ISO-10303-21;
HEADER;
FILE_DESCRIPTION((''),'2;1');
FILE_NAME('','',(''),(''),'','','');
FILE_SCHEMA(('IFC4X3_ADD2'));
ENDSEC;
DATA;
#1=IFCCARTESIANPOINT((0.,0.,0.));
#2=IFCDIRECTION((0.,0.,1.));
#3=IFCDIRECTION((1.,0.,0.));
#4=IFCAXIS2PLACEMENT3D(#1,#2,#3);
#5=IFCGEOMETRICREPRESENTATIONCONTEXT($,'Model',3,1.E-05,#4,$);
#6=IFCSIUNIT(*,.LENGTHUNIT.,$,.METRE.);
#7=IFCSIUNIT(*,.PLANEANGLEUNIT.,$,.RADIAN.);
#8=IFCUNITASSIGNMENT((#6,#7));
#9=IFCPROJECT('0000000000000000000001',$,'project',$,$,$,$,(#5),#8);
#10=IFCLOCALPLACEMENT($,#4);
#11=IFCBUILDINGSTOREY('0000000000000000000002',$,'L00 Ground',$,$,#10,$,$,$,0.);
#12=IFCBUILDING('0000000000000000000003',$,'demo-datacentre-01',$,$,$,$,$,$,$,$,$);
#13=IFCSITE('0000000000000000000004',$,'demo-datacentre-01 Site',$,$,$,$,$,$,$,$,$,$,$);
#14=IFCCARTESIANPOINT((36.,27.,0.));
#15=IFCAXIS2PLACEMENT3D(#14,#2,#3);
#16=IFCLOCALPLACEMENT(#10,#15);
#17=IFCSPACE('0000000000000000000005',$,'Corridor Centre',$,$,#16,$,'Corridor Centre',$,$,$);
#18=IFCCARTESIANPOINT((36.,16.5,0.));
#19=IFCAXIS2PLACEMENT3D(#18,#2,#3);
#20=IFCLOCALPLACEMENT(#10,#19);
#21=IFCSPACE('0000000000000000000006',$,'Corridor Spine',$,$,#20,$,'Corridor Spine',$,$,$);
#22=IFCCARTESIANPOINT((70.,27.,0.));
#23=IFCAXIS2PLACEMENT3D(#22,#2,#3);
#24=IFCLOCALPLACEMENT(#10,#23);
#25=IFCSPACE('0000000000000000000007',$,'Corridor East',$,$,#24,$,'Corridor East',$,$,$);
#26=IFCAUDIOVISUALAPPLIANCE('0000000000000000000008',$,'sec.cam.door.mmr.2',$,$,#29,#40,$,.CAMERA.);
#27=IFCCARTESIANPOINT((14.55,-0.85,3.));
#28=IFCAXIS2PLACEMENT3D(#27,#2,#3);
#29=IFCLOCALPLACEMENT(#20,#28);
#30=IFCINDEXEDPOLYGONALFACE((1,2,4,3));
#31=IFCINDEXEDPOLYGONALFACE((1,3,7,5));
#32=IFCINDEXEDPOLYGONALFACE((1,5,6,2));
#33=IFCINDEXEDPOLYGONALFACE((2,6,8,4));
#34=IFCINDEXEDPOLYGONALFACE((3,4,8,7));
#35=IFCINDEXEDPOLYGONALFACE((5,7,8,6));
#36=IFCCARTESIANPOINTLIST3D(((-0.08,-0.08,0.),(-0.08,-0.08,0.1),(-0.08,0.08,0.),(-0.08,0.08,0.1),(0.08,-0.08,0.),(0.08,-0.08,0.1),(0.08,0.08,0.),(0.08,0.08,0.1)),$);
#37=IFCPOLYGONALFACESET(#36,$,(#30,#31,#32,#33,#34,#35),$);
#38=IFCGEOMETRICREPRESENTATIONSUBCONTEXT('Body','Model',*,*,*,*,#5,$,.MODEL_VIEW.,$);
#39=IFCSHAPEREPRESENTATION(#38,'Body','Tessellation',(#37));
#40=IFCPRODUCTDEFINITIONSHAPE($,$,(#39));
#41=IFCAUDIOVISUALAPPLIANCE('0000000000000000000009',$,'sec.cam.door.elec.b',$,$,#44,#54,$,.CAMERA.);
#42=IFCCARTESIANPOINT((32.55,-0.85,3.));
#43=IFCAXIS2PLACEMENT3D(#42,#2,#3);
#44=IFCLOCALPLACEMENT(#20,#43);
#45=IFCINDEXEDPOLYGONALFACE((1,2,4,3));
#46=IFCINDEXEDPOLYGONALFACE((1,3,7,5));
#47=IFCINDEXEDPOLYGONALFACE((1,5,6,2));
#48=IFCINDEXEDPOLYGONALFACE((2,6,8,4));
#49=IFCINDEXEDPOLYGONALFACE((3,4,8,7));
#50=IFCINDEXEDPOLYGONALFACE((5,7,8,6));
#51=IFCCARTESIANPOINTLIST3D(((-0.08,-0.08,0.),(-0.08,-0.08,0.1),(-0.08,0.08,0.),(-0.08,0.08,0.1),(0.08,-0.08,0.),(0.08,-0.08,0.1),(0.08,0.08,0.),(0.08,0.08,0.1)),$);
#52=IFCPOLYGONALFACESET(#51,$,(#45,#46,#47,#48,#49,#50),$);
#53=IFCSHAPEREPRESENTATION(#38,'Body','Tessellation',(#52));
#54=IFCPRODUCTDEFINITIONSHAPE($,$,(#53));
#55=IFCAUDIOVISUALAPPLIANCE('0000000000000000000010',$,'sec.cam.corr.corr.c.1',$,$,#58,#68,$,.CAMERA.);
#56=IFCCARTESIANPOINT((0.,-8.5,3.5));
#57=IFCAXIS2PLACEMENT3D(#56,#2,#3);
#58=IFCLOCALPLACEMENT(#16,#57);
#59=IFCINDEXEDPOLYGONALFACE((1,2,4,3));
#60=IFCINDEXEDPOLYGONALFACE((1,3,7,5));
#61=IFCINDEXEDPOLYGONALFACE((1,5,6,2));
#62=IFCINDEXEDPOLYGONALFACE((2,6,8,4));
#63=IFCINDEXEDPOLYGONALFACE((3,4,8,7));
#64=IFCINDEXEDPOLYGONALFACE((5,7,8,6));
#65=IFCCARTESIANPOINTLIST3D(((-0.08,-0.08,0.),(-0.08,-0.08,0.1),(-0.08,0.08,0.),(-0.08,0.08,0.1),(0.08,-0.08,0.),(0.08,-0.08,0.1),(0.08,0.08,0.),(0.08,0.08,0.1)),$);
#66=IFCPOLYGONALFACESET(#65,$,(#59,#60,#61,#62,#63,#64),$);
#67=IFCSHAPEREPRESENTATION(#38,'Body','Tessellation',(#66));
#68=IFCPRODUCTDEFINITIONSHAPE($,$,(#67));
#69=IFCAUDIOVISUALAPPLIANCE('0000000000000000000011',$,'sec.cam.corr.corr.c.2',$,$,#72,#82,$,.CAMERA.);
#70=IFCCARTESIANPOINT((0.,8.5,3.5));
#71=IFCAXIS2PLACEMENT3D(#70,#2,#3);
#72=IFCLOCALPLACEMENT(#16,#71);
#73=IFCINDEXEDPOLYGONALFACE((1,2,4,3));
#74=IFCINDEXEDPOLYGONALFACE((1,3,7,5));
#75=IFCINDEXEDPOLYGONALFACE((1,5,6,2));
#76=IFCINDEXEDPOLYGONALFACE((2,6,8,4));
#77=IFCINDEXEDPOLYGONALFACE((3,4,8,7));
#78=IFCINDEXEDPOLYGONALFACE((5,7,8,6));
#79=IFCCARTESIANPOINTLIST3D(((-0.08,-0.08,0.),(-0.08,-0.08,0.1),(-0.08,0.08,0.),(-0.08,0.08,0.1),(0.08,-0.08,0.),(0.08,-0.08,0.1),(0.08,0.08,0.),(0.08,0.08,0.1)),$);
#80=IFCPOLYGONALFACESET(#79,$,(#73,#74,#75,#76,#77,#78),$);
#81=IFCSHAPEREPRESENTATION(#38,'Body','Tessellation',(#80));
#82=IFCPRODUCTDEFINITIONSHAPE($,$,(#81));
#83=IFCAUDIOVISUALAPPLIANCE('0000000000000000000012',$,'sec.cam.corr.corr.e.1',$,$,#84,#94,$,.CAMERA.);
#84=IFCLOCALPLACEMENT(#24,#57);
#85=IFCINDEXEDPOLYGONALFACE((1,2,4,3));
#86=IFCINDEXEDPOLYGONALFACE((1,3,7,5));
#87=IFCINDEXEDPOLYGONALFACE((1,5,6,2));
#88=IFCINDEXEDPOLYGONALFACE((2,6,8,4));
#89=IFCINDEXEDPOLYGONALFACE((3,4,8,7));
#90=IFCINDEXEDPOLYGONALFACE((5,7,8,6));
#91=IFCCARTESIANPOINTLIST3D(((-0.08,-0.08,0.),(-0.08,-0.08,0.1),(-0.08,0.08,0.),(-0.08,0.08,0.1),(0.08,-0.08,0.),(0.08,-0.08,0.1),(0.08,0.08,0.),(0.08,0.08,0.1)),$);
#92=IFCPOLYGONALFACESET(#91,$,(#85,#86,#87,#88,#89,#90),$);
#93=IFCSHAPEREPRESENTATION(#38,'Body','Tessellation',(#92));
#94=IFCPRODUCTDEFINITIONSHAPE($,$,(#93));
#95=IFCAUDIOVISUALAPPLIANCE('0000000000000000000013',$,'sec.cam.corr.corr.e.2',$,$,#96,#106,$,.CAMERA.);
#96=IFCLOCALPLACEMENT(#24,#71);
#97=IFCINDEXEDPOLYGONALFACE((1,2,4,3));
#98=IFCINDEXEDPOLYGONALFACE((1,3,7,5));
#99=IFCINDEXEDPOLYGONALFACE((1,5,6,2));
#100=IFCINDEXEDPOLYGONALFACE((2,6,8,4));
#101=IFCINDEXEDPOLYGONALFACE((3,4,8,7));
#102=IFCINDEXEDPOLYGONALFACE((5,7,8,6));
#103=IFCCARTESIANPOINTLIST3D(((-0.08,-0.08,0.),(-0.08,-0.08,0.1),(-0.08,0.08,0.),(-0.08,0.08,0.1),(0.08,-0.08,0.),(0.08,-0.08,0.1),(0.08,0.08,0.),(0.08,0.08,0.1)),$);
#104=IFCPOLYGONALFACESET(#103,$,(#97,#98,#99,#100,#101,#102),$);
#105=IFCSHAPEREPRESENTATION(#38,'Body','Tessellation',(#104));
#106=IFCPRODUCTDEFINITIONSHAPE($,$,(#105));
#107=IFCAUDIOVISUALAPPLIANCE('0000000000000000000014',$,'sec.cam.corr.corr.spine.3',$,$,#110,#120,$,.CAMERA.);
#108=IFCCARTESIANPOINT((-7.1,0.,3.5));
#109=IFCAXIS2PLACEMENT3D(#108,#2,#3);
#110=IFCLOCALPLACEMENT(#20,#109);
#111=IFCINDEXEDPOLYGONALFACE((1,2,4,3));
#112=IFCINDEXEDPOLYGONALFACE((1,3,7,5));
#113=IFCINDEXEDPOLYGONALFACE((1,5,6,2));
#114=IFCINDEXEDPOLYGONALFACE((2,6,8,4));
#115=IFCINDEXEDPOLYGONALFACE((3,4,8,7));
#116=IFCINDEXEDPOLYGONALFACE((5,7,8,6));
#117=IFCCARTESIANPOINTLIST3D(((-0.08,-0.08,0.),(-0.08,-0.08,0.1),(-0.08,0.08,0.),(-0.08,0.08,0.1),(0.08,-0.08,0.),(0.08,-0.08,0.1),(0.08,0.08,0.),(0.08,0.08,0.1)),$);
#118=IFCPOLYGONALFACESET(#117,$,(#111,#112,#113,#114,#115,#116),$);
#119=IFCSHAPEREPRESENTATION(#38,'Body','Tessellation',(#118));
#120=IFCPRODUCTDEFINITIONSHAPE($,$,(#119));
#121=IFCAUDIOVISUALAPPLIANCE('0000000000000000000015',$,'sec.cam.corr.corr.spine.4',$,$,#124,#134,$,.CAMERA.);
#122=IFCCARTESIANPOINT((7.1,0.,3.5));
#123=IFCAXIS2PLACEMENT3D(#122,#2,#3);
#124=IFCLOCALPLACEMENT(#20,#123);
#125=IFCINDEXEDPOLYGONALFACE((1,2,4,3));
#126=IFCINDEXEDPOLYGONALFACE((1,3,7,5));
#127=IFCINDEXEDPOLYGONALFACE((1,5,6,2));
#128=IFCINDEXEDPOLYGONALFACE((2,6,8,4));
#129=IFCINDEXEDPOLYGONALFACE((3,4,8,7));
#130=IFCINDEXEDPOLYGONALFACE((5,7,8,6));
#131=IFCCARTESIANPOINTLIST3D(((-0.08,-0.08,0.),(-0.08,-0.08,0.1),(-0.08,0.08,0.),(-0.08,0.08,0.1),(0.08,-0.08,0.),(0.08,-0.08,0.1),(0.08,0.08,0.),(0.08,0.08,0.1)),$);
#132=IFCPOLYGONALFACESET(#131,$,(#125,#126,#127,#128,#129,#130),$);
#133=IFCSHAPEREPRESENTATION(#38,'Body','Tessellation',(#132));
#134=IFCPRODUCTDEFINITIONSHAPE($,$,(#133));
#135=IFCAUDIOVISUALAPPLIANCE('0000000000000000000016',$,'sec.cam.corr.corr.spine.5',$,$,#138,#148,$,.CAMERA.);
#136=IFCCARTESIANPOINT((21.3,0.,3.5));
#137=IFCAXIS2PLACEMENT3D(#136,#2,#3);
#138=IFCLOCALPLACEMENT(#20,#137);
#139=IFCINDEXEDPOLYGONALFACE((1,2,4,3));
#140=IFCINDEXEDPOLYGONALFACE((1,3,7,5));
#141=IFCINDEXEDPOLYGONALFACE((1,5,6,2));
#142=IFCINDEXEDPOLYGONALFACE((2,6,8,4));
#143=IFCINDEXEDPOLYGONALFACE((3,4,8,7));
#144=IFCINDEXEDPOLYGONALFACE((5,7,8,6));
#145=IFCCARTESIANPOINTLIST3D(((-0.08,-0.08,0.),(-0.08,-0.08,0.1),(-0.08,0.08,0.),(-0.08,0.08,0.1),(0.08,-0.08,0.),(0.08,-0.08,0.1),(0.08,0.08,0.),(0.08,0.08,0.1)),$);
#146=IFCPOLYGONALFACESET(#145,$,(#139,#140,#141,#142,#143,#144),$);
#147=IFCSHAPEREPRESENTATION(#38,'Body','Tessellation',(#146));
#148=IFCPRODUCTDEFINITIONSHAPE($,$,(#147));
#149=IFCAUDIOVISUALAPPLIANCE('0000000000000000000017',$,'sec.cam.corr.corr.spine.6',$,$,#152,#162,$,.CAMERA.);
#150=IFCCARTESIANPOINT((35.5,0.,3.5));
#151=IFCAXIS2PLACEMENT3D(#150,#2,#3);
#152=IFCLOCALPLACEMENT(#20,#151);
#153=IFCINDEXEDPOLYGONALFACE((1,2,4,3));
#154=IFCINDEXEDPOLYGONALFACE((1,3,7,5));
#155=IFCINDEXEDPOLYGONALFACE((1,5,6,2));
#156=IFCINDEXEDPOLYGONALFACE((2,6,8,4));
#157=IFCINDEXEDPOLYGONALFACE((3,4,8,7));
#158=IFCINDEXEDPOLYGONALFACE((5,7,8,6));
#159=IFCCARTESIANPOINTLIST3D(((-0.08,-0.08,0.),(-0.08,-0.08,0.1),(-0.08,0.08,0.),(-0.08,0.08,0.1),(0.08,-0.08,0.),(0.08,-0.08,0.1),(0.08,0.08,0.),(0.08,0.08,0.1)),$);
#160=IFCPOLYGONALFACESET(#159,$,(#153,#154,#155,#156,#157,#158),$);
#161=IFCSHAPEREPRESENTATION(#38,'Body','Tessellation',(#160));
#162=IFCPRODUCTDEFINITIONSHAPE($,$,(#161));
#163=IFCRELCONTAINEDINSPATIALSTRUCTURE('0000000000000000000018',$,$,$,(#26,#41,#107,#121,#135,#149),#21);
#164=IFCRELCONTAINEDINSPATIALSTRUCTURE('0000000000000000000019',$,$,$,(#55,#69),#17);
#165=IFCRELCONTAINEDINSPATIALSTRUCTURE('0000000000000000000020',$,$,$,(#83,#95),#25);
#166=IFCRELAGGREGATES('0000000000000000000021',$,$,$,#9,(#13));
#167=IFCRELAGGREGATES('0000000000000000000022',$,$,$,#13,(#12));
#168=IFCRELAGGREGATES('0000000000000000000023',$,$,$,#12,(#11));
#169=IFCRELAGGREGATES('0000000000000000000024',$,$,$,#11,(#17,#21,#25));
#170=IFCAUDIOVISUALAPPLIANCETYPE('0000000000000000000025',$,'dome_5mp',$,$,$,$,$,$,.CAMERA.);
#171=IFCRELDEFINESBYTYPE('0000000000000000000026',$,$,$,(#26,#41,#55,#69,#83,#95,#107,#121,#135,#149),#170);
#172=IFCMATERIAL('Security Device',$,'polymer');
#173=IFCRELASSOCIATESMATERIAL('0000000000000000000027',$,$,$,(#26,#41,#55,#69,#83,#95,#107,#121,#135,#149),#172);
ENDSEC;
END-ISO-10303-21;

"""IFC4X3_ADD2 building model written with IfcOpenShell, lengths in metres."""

from ifc_helpers import new_model, si_unit, frame, origin_with_axes, place, context, subcontext, project, spatial, rectangle, extrude, source, transform, mapped, material, type_object, type_shapes, element, save


model = new_model("IFC4X3_ADD2")

# Units and contexts
model_context = context("Model", 3, precision=1e-05, world=origin_with_axes())
body_context = subcontext(model_context, "Body", "Model", "MODEL_VIEW")
ifc_project = project(units=[si_unit("LENGTHUNIT", "METRE"), si_unit("PLANEANGLEUNIT", "RADIAN")], contexts=[model_context])

# Site, building, storey
site = spatial("IfcSite", under=ifc_project, Name="demo-datacentre-01 Site")
building = spatial("IfcBuilding", under=site, Name="demo-datacentre-01")
storey_placement = place(None, origin_with_axes())
storey = spatial("IfcBuildingStorey", under=building, at=storey_placement, Name="L00 Ground", Elevation=0.0)

# Shared definitions
ifc_material = material(Name="Security Device", Category="polymer")

# Shared definitions
space_1_placement = place(storey_placement, frame((36.0, 27.0, 0.0), z_axis=(0.0, 0.0, 1.0), x_axis=(1.0, 0.0, 0.0)))
space_1 = spatial("IfcSpace", under=storey, at=space_1_placement, Name="Corridor Centre", LongName="Corridor Centre")

# Shared definitions
space_2_placement = place(storey_placement, frame((36.0, 16.5, 0.0), z_axis=(0.0, 0.0, 1.0), x_axis=(1.0, 0.0, 0.0)))
space_2 = spatial("IfcSpace", under=storey, at=space_2_placement, Name="Corridor Spine", LongName="Corridor Spine")

# Shared definitions
space_3_placement = place(storey_placement, frame((70.0, 27.0, 0.0), z_axis=(0.0, 0.0, 1.0), x_axis=(1.0, 0.0, 0.0)))
space_3 = spatial("IfcSpace", under=storey, at=space_3_placement, Name="Corridor East", LongName="Corridor East")

# Audio visual appliances
audio_visual_appliance_type = type_object("IfcAudioVisualApplianceType", Name="dome_5mp", PredefinedType="CAMERA")
shared_shape = source(origin_with_axes(), body_context, "Body", "SweptSolid", [
    extrude(rectangle(XDim=0.16, YDim=0.16), origin_with_axes(), (0.0, 0.0, 1.0), 0.1),
])
type_shapes(audio_visual_appliance_type, [shared_shape])
for number, where, z_axis, x_axis, name in (
    (1, (14.55, -0.85, 3.0), (0.0, 0.0, 1.0), (1.0, 0.0, 0.0), "sec.cam.door.mmr.2"),
    (2, (32.55, -0.85, 3.0), (0.0, 0.0, 1.0), (1.0, 0.0, 0.0), "sec.cam.door.elec.b"),
):
    element("IfcAudioVisualAppliance", number, at=place(space_2_placement, frame(where, z_axis=z_axis, x_axis=x_axis)), inside=space_2, type_object=audio_visual_appliance_type, material=ifc_material, Name=name, PredefinedType="CAMERA", context=body_context, shape_type="MappedRepresentation", body=[
        mapped(shared_shape, transform((0.0, 0.0, 0.0), x_axis=(1.0, 0.0, 0.0), y_axis=(0.0, 1.0, 0.0), z_axis=(0.0, 0.0, 1.0), scale=1.0)),
    ])
for number, where, z_axis, x_axis, name in (
    (3, (0.0, -8.5, 3.5), (0.0, 0.0, 1.0), (1.0, 0.0, 0.0), "sec.cam.corr.corr.c.1"),
    (4, (0.0, 8.5, 3.5), (0.0, 0.0, 1.0), (1.0, 0.0, 0.0), "sec.cam.corr.corr.c.2"),
):
    element("IfcAudioVisualAppliance", number, at=place(space_1_placement, frame(where, z_axis=z_axis, x_axis=x_axis)), inside=space_1, type_object=audio_visual_appliance_type, material=ifc_material, Name=name, PredefinedType="CAMERA", context=body_context, shape_type="MappedRepresentation", body=[
        mapped(shared_shape, transform((0.0, 0.0, 0.0), x_axis=(1.0, 0.0, 0.0), y_axis=(0.0, 1.0, 0.0), z_axis=(0.0, 0.0, 1.0), scale=1.0)),
    ])
for number, where, z_axis, x_axis, name in (
    (5, (0.0, -8.5, 3.5), (0.0, 0.0, 1.0), (1.0, 0.0, 0.0), "sec.cam.corr.corr.e.1"),
    (6, (0.0, 8.5, 3.5), (0.0, 0.0, 1.0), (1.0, 0.0, 0.0), "sec.cam.corr.corr.e.2"),
):
    element("IfcAudioVisualAppliance", number, at=place(space_3_placement, frame(where, z_axis=z_axis, x_axis=x_axis)), inside=space_3, type_object=audio_visual_appliance_type, material=ifc_material, Name=name, PredefinedType="CAMERA", context=body_context, shape_type="MappedRepresentation", body=[
        mapped(shared_shape, transform((0.0, 0.0, 0.0), x_axis=(1.0, 0.0, 0.0), y_axis=(0.0, 1.0, 0.0), z_axis=(0.0, 0.0, 1.0), scale=1.0)),
    ])
for number, where, z_axis, x_axis, name in (
    (7, (-7.1, 0.0, 3.5), (0.0, 0.0, 1.0), (1.0, 0.0, 0.0), "sec.cam.corr.corr.spine.3"),
    (8, (7.1, 0.0, 3.5), (0.0, 0.0, 1.0), (1.0, 0.0, 0.0), "sec.cam.corr.corr.spine.4"),
    (9, (21.3, 0.0, 3.5), (0.0, 0.0, 1.0), (1.0, 0.0, 0.0), "sec.cam.corr.corr.spine.5"),
    (10, (35.5, 0.0, 3.5), (0.0, 0.0, 1.0), (1.0, 0.0, 0.0), "sec.cam.corr.corr.spine.6"),
):
    element("IfcAudioVisualAppliance", number, at=place(space_2_placement, frame(where, z_axis=z_axis, x_axis=x_axis)), inside=space_2, type_object=audio_visual_appliance_type, material=ifc_material, Name=name, PredefinedType="CAMERA", context=body_context, shape_type="MappedRepresentation", body=[
        mapped(shared_shape, transform((0.0, 0.0, 0.0), x_axis=(1.0, 0.0, 0.0), y_axis=(0.0, 1.0, 0.0), z_axis=(0.0, 0.0, 1.0), scale=1.0)),
    ])

save(model, "model.ifc")
